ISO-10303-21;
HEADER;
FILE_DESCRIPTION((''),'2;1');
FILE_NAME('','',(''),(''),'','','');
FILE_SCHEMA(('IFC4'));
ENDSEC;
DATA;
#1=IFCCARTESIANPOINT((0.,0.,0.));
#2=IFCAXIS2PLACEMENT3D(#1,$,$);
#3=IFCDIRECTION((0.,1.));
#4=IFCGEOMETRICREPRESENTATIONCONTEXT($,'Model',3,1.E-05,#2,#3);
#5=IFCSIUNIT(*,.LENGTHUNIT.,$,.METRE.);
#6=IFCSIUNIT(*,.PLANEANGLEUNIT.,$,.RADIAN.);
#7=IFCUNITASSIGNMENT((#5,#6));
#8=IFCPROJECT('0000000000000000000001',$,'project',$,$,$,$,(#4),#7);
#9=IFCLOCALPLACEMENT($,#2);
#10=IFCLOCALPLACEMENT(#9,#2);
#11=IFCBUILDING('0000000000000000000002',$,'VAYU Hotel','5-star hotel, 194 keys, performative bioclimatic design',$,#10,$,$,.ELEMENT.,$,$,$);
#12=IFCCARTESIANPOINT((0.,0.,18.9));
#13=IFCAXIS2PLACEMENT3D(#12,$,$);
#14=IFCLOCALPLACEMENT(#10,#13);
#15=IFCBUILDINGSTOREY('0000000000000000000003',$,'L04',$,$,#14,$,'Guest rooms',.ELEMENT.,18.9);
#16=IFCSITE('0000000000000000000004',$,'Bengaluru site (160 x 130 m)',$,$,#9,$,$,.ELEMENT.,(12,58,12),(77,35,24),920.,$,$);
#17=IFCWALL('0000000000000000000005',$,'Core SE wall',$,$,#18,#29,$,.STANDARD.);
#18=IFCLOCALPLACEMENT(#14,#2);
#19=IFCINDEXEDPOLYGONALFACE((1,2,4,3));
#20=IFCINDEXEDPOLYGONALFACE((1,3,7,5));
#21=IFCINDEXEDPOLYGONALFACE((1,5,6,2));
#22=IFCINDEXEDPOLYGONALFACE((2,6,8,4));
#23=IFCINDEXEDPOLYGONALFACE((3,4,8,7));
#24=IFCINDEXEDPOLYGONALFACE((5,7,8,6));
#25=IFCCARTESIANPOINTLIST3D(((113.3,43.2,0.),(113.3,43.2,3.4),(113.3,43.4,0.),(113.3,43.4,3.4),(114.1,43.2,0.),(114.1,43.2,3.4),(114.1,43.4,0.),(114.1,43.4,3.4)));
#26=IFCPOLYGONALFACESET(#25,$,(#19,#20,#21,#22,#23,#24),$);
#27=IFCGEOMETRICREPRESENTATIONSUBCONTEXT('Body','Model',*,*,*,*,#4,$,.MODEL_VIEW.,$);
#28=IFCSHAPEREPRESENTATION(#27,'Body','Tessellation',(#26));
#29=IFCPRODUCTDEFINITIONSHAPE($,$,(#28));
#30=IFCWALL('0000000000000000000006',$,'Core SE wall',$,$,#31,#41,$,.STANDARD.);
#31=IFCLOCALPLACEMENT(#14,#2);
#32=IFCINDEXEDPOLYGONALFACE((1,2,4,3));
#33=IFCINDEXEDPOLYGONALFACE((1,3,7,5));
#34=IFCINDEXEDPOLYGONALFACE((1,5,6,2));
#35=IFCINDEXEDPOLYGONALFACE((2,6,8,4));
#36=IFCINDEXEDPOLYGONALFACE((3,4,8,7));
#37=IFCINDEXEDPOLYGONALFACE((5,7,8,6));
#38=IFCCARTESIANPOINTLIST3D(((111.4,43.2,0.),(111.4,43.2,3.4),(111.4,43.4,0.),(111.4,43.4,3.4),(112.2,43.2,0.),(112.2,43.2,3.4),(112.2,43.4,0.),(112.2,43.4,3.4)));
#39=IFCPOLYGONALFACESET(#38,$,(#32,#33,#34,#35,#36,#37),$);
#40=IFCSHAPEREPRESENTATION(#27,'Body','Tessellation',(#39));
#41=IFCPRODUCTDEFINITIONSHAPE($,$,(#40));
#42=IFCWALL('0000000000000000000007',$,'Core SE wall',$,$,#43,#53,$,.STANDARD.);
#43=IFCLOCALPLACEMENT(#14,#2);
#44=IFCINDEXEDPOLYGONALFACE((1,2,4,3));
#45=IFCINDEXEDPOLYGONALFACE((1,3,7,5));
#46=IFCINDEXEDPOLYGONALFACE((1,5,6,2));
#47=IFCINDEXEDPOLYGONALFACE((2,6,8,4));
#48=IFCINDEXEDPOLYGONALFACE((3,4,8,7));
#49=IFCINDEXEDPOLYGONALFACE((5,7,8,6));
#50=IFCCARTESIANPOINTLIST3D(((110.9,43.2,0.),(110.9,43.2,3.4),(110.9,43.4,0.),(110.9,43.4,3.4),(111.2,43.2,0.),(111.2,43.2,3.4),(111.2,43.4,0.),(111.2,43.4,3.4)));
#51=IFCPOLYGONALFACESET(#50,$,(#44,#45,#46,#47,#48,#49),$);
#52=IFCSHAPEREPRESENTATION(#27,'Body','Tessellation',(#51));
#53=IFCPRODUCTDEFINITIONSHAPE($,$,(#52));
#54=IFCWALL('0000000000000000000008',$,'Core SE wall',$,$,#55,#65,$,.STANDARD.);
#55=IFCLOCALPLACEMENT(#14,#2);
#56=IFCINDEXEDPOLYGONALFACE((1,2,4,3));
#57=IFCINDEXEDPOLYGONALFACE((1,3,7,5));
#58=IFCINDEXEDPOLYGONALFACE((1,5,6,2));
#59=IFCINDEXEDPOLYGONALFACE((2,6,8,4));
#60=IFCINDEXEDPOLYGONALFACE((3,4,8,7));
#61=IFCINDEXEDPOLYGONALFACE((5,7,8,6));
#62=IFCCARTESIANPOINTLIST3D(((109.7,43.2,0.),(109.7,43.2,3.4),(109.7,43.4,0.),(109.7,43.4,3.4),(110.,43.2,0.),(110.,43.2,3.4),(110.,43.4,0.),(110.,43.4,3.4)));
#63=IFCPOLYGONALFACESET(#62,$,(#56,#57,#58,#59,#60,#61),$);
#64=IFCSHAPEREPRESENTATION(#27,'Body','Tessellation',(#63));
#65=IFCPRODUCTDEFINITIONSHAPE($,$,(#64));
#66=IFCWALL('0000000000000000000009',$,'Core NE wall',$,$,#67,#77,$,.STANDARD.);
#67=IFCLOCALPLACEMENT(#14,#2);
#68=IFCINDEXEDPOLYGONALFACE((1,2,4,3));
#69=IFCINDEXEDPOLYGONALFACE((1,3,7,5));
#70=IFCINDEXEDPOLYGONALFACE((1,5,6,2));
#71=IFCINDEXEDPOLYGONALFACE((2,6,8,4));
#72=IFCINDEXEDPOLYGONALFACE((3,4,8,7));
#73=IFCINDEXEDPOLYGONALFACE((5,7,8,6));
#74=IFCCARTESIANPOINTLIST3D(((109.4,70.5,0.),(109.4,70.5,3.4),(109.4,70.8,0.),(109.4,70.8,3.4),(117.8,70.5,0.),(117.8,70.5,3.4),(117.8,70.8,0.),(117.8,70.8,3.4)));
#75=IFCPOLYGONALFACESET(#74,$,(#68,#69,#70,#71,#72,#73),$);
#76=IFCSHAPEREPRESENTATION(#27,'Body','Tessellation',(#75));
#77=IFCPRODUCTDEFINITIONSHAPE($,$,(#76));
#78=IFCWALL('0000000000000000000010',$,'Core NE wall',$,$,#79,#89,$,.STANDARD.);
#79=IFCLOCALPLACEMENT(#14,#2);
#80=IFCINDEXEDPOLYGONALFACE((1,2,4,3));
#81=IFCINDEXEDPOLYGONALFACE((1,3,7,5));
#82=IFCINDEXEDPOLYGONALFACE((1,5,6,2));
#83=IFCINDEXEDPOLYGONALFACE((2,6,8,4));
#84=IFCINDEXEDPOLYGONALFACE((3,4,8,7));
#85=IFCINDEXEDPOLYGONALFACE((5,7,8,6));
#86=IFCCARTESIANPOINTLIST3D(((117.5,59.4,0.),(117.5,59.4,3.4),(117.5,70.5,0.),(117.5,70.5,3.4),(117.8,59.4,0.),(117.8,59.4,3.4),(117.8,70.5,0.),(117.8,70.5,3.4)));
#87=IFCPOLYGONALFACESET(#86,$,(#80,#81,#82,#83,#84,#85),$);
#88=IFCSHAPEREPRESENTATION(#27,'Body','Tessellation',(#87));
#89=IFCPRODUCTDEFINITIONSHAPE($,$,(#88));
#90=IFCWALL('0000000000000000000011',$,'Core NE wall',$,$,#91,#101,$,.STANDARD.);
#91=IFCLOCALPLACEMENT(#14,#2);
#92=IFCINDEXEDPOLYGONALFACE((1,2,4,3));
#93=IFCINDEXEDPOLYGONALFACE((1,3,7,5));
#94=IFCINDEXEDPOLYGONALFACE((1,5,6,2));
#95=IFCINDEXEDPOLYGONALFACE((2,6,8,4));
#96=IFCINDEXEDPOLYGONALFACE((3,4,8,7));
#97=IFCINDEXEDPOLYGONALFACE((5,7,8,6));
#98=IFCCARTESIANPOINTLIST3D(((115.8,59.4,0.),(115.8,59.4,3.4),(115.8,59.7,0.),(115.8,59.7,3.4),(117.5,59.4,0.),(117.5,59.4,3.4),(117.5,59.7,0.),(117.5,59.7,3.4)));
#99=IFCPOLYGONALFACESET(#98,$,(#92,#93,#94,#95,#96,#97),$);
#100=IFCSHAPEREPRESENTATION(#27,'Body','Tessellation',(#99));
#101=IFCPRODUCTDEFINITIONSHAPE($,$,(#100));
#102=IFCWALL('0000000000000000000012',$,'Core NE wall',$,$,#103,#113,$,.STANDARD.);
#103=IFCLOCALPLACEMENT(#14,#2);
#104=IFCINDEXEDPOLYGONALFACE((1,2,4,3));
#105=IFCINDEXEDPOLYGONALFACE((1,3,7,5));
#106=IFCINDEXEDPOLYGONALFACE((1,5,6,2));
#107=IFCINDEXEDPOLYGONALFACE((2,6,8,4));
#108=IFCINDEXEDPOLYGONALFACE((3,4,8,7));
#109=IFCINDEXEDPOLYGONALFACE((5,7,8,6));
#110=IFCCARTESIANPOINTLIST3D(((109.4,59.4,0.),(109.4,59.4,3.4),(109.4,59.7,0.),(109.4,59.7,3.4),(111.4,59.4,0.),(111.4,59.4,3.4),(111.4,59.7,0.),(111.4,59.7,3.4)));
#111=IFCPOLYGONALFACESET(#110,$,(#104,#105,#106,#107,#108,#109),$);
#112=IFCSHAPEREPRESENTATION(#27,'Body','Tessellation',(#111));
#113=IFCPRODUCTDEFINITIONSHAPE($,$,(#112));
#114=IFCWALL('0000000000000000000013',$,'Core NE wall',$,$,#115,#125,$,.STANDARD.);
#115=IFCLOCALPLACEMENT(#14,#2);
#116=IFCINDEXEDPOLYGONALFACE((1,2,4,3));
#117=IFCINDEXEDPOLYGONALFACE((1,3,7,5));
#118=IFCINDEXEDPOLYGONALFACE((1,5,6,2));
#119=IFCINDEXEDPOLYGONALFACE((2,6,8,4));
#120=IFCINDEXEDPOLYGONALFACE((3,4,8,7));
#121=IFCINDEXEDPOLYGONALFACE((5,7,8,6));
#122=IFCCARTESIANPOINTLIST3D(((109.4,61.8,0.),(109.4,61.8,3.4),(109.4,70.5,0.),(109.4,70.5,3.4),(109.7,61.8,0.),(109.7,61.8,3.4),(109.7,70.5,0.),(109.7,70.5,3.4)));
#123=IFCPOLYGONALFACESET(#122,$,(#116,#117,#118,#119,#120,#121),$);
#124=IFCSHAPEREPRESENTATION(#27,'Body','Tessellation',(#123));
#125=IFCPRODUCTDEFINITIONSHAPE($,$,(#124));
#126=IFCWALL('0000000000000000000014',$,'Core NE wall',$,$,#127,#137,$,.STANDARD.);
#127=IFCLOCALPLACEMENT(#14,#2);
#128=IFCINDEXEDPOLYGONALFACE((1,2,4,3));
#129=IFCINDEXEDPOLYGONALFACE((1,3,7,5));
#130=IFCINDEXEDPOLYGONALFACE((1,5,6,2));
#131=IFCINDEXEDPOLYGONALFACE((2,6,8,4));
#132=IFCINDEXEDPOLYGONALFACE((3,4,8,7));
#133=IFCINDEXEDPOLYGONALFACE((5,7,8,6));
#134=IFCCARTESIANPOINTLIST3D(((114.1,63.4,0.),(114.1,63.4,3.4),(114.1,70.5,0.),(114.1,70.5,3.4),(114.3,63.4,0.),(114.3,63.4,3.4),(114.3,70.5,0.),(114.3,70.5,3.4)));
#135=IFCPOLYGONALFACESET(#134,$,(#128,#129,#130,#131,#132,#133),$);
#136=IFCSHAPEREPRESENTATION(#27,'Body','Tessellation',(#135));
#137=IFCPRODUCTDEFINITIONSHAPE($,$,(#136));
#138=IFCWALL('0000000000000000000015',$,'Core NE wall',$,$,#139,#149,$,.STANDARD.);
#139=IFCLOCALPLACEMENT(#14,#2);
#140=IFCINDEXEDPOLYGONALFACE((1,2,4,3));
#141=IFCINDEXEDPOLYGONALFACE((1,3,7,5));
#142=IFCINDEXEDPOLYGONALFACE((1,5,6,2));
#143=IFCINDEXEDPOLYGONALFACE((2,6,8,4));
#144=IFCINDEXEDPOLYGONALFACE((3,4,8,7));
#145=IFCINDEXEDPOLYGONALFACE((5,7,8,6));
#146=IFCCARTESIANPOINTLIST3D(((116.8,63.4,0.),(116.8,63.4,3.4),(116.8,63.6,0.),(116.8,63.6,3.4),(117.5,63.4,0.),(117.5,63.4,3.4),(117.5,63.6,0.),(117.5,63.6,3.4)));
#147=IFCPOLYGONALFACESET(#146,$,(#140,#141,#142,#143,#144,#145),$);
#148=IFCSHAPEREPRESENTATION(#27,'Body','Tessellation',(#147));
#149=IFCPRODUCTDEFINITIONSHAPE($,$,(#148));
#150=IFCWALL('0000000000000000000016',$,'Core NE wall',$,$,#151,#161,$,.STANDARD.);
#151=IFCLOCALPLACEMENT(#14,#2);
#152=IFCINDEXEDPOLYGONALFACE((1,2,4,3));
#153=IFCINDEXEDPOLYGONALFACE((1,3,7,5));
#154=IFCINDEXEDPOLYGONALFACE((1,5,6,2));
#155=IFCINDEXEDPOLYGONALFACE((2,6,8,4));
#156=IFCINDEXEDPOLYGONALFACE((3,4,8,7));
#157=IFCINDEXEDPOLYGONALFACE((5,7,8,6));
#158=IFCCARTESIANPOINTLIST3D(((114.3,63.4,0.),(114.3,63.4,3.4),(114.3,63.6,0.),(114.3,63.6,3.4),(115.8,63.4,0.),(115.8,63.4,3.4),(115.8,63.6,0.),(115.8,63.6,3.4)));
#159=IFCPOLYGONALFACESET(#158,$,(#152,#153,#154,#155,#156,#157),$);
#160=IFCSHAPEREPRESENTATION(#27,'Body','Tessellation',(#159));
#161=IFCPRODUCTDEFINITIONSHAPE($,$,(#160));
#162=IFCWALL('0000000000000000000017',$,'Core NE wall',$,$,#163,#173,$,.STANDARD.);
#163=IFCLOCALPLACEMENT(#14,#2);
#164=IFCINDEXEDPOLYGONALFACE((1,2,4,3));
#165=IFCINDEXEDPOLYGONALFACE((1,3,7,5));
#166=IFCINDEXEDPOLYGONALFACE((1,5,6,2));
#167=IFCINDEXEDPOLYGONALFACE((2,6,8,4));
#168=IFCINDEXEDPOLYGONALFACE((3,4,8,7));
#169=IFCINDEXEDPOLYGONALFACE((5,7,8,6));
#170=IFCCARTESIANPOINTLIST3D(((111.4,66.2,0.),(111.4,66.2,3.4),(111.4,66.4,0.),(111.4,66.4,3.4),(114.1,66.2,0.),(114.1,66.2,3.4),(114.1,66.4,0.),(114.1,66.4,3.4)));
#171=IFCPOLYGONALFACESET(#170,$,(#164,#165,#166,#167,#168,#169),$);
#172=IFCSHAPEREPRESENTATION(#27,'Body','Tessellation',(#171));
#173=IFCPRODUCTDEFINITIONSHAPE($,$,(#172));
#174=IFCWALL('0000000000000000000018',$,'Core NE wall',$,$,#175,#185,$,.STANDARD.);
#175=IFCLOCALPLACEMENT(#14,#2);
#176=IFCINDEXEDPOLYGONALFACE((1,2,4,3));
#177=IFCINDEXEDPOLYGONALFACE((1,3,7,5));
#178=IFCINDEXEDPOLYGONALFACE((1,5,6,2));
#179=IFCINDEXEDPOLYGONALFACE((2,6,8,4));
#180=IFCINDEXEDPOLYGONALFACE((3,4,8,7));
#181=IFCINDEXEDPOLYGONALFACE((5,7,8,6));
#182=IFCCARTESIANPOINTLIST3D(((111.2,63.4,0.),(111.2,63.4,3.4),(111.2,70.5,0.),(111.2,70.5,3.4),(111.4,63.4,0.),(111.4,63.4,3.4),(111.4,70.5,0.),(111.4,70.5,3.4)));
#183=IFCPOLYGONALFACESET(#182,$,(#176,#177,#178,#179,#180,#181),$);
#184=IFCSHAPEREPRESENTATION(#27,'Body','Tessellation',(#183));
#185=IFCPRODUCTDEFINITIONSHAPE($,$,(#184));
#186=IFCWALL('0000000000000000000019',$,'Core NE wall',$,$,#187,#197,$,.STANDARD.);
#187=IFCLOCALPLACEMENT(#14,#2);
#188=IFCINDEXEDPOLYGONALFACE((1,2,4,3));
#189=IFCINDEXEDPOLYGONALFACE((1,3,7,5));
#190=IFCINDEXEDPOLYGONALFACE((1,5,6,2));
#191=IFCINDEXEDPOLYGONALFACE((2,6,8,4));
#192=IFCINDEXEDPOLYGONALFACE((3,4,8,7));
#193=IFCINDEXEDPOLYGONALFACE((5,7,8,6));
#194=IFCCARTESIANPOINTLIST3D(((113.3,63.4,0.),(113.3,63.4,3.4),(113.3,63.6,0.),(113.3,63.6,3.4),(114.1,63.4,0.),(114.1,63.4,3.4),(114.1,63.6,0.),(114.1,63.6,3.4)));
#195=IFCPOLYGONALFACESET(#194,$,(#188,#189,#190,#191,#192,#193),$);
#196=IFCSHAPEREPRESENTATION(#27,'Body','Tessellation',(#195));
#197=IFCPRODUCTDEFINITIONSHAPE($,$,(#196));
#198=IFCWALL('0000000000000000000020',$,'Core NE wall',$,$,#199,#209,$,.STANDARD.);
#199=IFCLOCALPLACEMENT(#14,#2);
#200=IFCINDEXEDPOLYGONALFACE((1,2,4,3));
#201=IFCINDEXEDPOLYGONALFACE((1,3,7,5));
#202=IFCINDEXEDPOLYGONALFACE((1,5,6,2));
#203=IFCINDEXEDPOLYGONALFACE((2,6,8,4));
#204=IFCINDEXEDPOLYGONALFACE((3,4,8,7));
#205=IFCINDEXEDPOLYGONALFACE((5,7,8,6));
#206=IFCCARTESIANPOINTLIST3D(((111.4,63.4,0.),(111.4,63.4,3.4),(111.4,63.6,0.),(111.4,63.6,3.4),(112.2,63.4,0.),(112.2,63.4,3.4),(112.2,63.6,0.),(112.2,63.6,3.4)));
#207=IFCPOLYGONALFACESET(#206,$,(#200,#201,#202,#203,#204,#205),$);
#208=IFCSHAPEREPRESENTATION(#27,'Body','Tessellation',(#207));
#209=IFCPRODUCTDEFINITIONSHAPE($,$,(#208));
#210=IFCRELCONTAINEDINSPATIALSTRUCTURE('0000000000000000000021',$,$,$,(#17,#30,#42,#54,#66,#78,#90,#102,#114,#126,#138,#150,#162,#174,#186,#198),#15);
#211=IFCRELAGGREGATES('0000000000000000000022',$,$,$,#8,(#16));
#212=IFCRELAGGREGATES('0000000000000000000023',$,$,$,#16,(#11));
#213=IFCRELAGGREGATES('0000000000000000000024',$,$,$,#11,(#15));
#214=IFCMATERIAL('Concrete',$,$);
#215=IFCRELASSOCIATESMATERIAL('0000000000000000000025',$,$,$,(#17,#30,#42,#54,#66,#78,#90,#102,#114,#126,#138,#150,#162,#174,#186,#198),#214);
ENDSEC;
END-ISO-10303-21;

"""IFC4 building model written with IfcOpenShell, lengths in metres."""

from ifc_helpers import new_model, si_unit, direction, frame, origin, place, context, subcontext, project, spatial, polyline, outline, extrude, material, element, save


model = new_model("IFC4")

# Units and contexts
model_context = context("Model", 3, precision=1e-05, world=origin(), true_north=direction((0.0, 1.0)))
body_context = subcontext(model_context, "Body", "Model", "MODEL_VIEW")
ifc_project = project(units=[si_unit("LENGTHUNIT", "METRE"), si_unit("PLANEANGLEUNIT", "RADIAN")], contexts=[model_context])

# Site, building, storey
site_placement = place(None, origin())
site = spatial("IfcSite", under=ifc_project, at=site_placement, Name="Bengaluru site (160 x 130 m)", CompositionType="ELEMENT", RefLatitude=(12, 58, 12), RefLongitude=(77, 35, 24), RefElevation=920.0)
building_placement = place(site_placement, origin())
building = spatial("IfcBuilding", under=site, at=building_placement, Name="VAYU Hotel", Description="5-star hotel, 194 keys, performative bioclimatic design", CompositionType="ELEMENT")
storey_placement = place(building_placement, frame((0.0, 0.0, 18.9)))
storey = spatial("IfcBuildingStorey", under=building, at=storey_placement, Name="L04", LongName="Guest rooms", CompositionType="ELEMENT", Elevation=18.9)

# Shared definitions
ifc_material_1 = material(Name="Concrete")

# Walls
wall_1_placement = place(storey_placement, origin())
element("IfcWall", 1, at=wall_1_placement, inside=storey, material=ifc_material_1, Name="Core SE wall", PredefinedType="STANDARD", context=body_context, shape_type="SweptSolid", body=[
    extrude(outline(polyline([(113.3, 43.4), (114.1, 43.4), (114.1, 43.2), (113.3, 43.2), (113.3, 43.4)])), origin(), (0.0, 0.0, 1.0), 3.4),
])
wall_2_placement = place(storey_placement, origin())
element("IfcWall", 2, at=wall_2_placement, inside=storey, material=ifc_material_1, Name="Core SE wall", PredefinedType="STANDARD", context=body_context, shape_type="SweptSolid", body=[
    extrude(outline(polyline([(111.4, 43.4), (112.2, 43.4), (112.2, 43.2), (111.4, 43.2), (111.4, 43.4)])), origin(), (0.0, 0.0, 1.0), 3.4),
])
wall_3_placement = place(storey_placement, origin())
element("IfcWall", 3, at=wall_3_placement, inside=storey, material=ifc_material_1, Name="Core SE wall", PredefinedType="STANDARD", context=body_context, shape_type="SweptSolid", body=[
    extrude(outline(polyline([(110.9, 43.4), (111.2, 43.4), (111.2, 43.2), (110.9, 43.2), (110.9, 43.4)])), origin(), (0.0, 0.0, 1.0), 3.4),
])
wall_4_placement = place(storey_placement, origin())
element("IfcWall", 4, at=wall_4_placement, inside=storey, material=ifc_material_1, Name="Core SE wall", PredefinedType="STANDARD", context=body_context, shape_type="SweptSolid", body=[
    extrude(outline(polyline([(109.7, 43.4), (110.0, 43.4), (110.0, 43.2), (109.7, 43.2), (109.7, 43.4)])), origin(), (0.0, 0.0, 1.0), 3.4),
])
wall_5_placement = place(storey_placement, origin())
element("IfcWall", 5, at=wall_5_placement, inside=storey, material=ifc_material_1, Name="Core NE wall", PredefinedType="STANDARD", context=body_context, shape_type="SweptSolid", body=[
    extrude(outline(polyline([(109.4, 70.8), (117.8, 70.8), (117.8, 70.5), (109.4, 70.5), (109.4, 70.8)])), origin(), (0.0, 0.0, 1.0), 3.4),
])
wall_6_placement = place(storey_placement, origin())
element("IfcWall", 6, at=wall_6_placement, inside=storey, material=ifc_material_1, Name="Core NE wall", PredefinedType="STANDARD", context=body_context, shape_type="SweptSolid", body=[
    extrude(outline(polyline([(117.5, 59.4), (117.5, 70.5), (117.8, 70.5), (117.8, 59.4), (117.5, 59.4)])), origin(), (0.0, 0.0, 1.0), 3.4),
])
wall_7_placement = place(storey_placement, origin())
element("IfcWall", 7, at=wall_7_placement, inside=storey, material=ifc_material_1, Name="Core NE wall", PredefinedType="STANDARD", context=body_context, shape_type="SweptSolid", body=[
    extrude(outline(polyline([(115.8, 59.7), (117.5, 59.7), (117.5, 59.4), (115.8, 59.4), (115.8, 59.7)])), origin(), (0.0, 0.0, 1.0), 3.4),
])
wall_8_placement = place(storey_placement, origin())
element("IfcWall", 8, at=wall_8_placement, inside=storey, material=ifc_material_1, Name="Core NE wall", PredefinedType="STANDARD", context=body_context, shape_type="SweptSolid", body=[
    extrude(outline(polyline([(109.4, 59.7), (111.4, 59.7), (111.4, 59.4), (109.4, 59.4), (109.4, 59.7)])), origin(), (0.0, 0.0, 1.0), 3.4),
])
wall_9_placement = place(storey_placement, origin())
element("IfcWall", 9, at=wall_9_placement, inside=storey, material=ifc_material_1, Name="Core NE wall", PredefinedType="STANDARD", context=body_context, shape_type="SweptSolid", body=[
    extrude(outline(polyline([(109.4, 61.8), (109.4, 70.5), (109.7, 70.5), (109.7, 61.8), (109.4, 61.8)])), origin(), (0.0, 0.0, 1.0), 3.4),
])
wall_10_placement = place(storey_placement, origin())
element("IfcWall", 10, at=wall_10_placement, inside=storey, material=ifc_material_1, Name="Core NE wall", PredefinedType="STANDARD", context=body_context, shape_type="SweptSolid", body=[
    extrude(outline(polyline([(114.1, 63.4), (114.1, 70.5), (114.3, 70.5), (114.3, 63.4), (114.1, 63.4)])), origin(), (0.0, 0.0, 1.0), 3.4),
])
wall_11_placement = place(storey_placement, origin())
element("IfcWall", 11, at=wall_11_placement, inside=storey, material=ifc_material_1, Name="Core NE wall", PredefinedType="STANDARD", context=body_context, shape_type="SweptSolid", body=[
    extrude(outline(polyline([(116.8, 63.6), (117.5, 63.6), (117.5, 63.4), (116.8, 63.4), (116.8, 63.6)])), origin(), (0.0, 0.0, 1.0), 3.4),
])
wall_12_placement = place(storey_placement, origin())
element("IfcWall", 12, at=wall_12_placement, inside=storey, material=ifc_material_1, Name="Core NE wall", PredefinedType="STANDARD", context=body_context, shape_type="SweptSolid", body=[
    extrude(outline(polyline([(114.3, 63.6), (115.8, 63.6), (115.8, 63.4), (114.3, 63.4), (114.3, 63.6)])), origin(), (0.0, 0.0, 1.0), 3.4),
])
wall_13_placement = place(storey_placement, origin())
element("IfcWall", 13, at=wall_13_placement, inside=storey, material=ifc_material_1, Name="Core NE wall", PredefinedType="STANDARD", context=body_context, shape_type="SweptSolid", body=[
    extrude(outline(polyline([(111.4, 66.4), (114.1, 66.4), (114.1, 66.2), (111.4, 66.2), (111.4, 66.4)])), origin(), (0.0, 0.0, 1.0), 3.4),
])
wall_14_placement = place(storey_placement, origin())
element("IfcWall", 14, at=wall_14_placement, inside=storey, material=ifc_material_1, Name="Core NE wall", PredefinedType="STANDARD", context=body_context, shape_type="SweptSolid", body=[
    extrude(outline(polyline([(111.2, 63.4), (111.2, 70.5), (111.4, 70.5), (111.4, 63.4), (111.2, 63.4)])), origin(), (0.0, 0.0, 1.0), 3.4),
])
wall_15_placement = place(storey_placement, origin())
element("IfcWall", 15, at=wall_15_placement, inside=storey, material=ifc_material_1, Name="Core NE wall", PredefinedType="STANDARD", context=body_context, shape_type="SweptSolid", body=[
    extrude(outline(polyline([(113.3, 63.6), (114.1, 63.6), (114.1, 63.4), (113.3, 63.4), (113.3, 63.6)])), origin(), (0.0, 0.0, 1.0), 3.4),
])
wall_16_placement = place(storey_placement, origin())
element("IfcWall", 16, at=wall_16_placement, inside=storey, material=ifc_material_1, Name="Core NE wall", PredefinedType="STANDARD", context=body_context, shape_type="SweptSolid", body=[
    extrude(outline(polyline([(111.4, 63.6), (112.2, 63.6), (112.2, 63.4), (111.4, 63.4), (111.4, 63.6)])), origin(), (0.0, 0.0, 1.0), 3.4),
])

save(model, "model.ifc")
